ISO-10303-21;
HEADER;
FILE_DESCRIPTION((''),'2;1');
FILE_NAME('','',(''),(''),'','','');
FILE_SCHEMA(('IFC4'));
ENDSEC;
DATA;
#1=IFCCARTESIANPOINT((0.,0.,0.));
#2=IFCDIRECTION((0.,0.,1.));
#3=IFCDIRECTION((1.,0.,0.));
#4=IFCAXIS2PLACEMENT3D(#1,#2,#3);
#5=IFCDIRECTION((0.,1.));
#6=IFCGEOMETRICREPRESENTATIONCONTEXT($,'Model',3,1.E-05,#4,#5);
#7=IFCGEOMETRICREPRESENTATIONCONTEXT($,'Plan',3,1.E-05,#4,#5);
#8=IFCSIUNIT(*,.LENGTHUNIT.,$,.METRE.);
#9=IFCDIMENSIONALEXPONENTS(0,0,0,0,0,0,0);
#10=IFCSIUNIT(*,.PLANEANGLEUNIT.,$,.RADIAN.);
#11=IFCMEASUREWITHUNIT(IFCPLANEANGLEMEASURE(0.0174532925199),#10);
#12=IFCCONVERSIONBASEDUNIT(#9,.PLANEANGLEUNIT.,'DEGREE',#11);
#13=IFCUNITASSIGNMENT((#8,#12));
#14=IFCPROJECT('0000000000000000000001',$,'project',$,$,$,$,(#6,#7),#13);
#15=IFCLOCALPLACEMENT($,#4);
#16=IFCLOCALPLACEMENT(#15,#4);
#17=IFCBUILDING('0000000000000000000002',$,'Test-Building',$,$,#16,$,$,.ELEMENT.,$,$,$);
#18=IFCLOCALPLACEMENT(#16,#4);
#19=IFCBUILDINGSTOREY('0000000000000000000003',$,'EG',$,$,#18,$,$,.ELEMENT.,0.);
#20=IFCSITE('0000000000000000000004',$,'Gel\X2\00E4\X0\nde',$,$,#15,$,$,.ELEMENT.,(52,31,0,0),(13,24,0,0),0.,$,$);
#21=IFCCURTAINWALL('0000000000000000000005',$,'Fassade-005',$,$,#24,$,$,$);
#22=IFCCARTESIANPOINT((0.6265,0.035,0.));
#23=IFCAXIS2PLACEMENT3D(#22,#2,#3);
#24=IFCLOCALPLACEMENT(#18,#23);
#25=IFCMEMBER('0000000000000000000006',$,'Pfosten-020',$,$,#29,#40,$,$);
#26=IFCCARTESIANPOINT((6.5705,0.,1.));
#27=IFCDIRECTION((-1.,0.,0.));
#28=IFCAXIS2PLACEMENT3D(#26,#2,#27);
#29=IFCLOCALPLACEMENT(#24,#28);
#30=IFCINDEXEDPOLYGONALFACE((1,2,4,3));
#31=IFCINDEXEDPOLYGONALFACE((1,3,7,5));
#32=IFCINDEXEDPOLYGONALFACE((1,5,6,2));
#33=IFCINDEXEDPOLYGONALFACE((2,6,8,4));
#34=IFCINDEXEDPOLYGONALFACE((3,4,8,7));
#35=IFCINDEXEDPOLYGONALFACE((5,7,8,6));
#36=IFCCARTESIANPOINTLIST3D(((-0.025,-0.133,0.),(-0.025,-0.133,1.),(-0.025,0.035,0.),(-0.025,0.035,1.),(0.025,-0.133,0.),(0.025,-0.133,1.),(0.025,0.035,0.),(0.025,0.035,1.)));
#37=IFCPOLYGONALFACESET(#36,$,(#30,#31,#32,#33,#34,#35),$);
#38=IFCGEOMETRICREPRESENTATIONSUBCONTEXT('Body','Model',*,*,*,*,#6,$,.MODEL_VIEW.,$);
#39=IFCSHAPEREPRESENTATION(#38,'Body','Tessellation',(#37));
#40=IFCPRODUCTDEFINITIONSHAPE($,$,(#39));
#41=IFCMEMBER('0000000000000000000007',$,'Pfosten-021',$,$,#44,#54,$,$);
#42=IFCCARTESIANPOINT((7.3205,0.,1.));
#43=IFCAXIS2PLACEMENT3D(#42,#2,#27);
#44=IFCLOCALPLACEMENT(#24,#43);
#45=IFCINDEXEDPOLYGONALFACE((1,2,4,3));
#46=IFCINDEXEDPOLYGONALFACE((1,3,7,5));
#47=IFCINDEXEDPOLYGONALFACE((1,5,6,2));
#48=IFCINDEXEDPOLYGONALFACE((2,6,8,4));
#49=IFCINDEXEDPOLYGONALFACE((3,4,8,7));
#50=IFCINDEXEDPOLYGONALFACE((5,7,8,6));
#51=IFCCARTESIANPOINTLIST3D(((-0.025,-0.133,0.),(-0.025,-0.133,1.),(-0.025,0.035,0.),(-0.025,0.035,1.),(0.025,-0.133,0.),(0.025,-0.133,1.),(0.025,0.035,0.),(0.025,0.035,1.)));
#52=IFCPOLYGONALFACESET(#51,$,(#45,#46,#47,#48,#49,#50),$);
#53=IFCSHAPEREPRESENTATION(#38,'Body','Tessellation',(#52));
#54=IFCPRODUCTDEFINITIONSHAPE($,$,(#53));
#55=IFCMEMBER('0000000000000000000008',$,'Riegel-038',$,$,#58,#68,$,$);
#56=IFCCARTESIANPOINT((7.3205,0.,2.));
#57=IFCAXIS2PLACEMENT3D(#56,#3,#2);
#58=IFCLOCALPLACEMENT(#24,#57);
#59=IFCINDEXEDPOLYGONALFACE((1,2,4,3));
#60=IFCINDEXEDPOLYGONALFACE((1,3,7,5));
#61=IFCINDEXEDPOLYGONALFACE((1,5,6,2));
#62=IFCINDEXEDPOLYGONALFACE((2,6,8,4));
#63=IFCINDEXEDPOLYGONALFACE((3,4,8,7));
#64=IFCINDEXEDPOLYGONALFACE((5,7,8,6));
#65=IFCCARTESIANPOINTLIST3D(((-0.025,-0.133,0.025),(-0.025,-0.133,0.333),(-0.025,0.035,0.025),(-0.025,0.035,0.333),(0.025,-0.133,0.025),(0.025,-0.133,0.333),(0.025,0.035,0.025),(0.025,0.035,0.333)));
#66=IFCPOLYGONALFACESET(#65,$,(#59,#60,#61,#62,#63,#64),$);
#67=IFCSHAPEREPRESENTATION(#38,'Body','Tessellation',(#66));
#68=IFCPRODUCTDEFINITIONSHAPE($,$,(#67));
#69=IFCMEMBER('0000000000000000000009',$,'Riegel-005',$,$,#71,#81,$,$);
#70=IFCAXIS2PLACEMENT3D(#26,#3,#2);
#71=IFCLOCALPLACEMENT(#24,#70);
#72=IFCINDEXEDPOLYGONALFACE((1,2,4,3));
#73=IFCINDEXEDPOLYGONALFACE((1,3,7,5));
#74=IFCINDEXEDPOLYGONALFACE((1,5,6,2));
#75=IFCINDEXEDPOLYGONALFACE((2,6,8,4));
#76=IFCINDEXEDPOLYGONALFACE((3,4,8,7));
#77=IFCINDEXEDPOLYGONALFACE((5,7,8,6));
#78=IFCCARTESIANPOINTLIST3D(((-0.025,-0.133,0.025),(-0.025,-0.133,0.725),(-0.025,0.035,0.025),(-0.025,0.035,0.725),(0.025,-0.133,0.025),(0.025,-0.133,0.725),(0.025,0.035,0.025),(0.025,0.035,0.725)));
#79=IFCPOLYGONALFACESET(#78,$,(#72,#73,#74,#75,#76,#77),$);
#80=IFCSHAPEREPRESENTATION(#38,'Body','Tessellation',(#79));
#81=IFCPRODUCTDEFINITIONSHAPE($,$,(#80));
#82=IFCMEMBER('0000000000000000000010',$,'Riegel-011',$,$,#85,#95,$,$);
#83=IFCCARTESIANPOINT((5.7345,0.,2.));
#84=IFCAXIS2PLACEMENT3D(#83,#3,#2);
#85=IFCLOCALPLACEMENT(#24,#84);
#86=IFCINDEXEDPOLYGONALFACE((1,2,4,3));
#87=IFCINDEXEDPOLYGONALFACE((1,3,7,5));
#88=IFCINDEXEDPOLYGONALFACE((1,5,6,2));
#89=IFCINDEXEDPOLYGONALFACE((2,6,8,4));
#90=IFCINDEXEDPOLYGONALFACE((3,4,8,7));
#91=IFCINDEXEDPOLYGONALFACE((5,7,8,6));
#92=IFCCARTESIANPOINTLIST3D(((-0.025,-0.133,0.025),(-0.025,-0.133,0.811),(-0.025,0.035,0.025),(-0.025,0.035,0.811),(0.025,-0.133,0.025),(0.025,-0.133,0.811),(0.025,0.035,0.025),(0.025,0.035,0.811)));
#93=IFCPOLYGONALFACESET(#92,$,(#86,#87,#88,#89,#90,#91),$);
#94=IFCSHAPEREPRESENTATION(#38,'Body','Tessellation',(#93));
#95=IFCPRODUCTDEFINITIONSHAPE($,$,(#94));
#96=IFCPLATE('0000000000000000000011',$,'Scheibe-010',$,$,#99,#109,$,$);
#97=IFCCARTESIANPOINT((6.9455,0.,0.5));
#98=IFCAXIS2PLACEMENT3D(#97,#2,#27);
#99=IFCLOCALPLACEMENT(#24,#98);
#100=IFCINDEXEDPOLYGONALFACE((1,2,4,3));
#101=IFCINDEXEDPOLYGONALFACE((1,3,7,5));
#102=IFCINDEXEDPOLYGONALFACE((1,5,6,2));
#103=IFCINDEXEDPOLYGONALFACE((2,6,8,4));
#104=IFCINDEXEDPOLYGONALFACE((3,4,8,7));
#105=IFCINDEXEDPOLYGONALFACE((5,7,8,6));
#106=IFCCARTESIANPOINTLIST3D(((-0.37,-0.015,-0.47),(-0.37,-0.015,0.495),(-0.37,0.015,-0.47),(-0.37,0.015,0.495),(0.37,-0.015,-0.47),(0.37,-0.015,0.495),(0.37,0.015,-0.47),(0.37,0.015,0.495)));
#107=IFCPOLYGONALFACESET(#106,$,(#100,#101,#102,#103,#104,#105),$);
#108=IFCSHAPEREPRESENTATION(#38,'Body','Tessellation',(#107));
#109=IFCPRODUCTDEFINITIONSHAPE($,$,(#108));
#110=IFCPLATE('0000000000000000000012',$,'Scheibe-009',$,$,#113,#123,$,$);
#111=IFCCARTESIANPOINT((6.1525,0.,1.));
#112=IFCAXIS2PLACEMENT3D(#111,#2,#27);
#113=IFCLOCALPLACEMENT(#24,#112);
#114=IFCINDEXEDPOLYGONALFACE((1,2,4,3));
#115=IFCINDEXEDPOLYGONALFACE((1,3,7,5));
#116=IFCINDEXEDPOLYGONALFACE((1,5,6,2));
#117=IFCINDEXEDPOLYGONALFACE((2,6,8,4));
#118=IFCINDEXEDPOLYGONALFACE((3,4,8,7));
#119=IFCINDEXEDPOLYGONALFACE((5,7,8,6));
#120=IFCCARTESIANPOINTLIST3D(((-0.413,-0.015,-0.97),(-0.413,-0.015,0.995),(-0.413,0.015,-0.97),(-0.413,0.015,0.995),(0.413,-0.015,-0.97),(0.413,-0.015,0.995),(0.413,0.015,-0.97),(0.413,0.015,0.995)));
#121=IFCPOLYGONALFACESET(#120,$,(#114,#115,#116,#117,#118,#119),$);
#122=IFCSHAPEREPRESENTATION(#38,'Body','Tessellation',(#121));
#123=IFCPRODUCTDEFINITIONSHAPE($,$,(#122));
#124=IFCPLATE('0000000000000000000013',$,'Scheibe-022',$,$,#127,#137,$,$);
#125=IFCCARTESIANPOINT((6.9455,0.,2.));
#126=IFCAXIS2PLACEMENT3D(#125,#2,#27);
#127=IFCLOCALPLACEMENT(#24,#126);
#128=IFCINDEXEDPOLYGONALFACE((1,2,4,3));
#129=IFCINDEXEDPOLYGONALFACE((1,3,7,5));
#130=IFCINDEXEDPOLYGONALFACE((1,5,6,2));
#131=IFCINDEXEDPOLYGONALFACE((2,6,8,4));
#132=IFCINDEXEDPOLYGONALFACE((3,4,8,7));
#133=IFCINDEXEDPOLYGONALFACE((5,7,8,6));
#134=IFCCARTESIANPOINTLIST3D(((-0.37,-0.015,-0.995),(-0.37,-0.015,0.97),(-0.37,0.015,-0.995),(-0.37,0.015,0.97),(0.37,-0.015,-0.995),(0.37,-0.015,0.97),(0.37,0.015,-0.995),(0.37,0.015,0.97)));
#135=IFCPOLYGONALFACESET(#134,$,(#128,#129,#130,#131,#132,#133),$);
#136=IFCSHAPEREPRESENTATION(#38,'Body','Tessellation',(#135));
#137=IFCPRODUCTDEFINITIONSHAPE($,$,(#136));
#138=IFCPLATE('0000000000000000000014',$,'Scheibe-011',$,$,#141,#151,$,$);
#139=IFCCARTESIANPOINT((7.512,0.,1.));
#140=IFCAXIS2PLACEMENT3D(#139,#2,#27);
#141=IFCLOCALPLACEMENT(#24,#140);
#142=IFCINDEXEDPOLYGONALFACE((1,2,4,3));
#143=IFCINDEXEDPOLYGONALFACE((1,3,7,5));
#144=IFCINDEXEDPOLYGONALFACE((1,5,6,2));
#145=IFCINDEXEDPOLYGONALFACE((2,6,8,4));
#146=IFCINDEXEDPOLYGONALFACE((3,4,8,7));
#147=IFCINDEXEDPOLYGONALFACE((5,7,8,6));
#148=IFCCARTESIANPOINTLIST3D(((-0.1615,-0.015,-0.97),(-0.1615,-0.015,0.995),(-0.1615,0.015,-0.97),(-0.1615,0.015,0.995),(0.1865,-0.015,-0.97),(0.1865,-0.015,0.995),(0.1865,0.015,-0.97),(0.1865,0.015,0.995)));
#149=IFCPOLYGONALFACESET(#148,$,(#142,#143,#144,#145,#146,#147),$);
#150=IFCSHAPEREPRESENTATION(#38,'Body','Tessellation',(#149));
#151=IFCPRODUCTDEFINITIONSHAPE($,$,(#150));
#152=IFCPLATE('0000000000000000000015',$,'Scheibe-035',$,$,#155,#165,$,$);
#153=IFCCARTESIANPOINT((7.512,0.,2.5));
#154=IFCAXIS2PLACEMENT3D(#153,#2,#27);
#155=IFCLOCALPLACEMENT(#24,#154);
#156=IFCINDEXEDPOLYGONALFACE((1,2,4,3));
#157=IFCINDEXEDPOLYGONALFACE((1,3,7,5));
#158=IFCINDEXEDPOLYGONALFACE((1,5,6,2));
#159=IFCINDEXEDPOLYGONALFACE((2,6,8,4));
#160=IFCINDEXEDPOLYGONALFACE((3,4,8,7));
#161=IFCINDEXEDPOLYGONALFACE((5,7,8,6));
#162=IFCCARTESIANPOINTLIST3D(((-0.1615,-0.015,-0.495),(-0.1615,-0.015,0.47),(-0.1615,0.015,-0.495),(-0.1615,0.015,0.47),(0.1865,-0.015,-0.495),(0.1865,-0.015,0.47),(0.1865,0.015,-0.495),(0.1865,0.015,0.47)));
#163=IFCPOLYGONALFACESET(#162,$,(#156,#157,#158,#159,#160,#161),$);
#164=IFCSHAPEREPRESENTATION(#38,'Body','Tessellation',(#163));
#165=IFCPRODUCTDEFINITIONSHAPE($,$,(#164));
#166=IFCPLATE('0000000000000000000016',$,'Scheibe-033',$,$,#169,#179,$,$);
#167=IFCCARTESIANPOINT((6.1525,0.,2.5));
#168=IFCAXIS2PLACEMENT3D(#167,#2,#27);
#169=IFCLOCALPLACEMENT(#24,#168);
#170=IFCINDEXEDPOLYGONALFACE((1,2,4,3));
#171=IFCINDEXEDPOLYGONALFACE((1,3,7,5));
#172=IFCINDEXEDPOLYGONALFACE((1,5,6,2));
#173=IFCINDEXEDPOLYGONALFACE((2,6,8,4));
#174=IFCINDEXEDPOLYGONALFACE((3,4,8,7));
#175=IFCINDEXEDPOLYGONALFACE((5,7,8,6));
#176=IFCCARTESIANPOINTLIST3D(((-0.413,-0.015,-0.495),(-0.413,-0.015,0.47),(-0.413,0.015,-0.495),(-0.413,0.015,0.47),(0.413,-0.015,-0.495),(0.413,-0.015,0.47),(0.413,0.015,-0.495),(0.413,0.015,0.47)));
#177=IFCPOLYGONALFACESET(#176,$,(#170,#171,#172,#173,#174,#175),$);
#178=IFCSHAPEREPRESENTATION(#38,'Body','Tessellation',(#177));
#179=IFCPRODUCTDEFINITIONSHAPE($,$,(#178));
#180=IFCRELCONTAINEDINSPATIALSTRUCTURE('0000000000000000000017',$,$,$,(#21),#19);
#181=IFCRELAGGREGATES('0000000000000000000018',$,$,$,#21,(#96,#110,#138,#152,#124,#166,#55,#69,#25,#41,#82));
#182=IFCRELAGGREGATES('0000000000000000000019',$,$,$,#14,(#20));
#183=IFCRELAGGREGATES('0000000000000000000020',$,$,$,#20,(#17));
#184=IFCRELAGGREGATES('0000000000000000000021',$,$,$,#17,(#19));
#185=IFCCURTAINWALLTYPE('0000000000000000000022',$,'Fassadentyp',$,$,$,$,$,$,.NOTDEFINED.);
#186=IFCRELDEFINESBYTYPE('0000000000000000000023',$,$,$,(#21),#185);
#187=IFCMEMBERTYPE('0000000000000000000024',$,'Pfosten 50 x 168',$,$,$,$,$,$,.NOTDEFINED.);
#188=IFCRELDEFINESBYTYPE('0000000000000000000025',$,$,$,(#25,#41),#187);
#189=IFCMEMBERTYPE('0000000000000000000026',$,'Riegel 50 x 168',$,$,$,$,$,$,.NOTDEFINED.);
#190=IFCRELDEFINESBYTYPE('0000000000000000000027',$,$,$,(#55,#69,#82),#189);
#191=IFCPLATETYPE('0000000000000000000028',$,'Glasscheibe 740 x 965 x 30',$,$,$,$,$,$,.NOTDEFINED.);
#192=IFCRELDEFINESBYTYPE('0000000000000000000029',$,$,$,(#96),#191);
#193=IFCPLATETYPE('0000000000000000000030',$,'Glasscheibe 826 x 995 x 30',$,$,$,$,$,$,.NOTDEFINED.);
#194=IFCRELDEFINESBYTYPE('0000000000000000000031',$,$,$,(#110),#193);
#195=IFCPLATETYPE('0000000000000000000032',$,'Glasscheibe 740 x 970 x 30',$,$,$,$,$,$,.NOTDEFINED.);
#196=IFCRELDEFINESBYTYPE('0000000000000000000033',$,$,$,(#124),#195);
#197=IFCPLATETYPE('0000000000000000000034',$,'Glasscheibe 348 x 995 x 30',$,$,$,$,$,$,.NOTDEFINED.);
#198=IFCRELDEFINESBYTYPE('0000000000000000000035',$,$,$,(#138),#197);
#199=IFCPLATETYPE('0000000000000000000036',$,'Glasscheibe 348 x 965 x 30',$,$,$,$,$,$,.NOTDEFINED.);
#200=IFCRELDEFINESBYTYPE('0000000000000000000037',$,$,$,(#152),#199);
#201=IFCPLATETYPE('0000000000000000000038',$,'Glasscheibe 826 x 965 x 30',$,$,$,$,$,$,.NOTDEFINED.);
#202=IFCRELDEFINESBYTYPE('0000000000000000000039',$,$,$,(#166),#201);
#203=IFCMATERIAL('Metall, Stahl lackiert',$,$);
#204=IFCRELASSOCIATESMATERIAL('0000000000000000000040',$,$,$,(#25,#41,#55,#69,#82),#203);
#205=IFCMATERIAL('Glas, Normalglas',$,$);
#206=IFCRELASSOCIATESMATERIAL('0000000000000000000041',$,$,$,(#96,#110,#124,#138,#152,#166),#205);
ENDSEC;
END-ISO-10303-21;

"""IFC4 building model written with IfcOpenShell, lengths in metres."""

from ifc_helpers import new_model, entity, si_unit, converted_unit, direction, frame, origin_with_axes, place, context, subcontext, project, spatial, polyline, outline, extrude, material, type_object, element, aggregate, save


model = new_model("IFC4")

# Units and contexts
model_context = context("Model", 3, precision=1e-05, world=origin_with_axes(), true_north=direction((0.0, 1.0)))
plan_context = context("Plan", 3, precision=1e-05, world=origin_with_axes(), true_north=direction((0.0, 1.0)))
body_context = subcontext(model_context, "Body", "Model", "MODEL_VIEW")
ifc_project = project(units=[si_unit("LENGTHUNIT", "METRE"), converted_unit("PLANEANGLEUNIT", "DEGREE", entity("IfcPlaneAngleMeasure", 0.0174532925199), si_unit("PLANEANGLEUNIT", "RADIAN"), dimensions=[0, 0, 0, 0, 0, 0, 0])], contexts=[model_context, plan_context])

# Site, building, storey
site_placement = place(None, origin_with_axes())
site = spatial("IfcSite", under=ifc_project, at=site_placement, Name="Gelände", CompositionType="ELEMENT", RefLatitude=(52, 31, 0, 0), RefLongitude=(13, 24, 0, 0), RefElevation=0.0)
building_placement = place(site_placement, origin_with_axes())
building = spatial("IfcBuilding", under=site, at=building_placement, Name="Test-Building", CompositionType="ELEMENT")
storey_placement = place(building_placement, origin_with_axes())
storey = spatial("IfcBuildingStorey", under=building, at=storey_placement, Name="EG", CompositionType="ELEMENT", Elevation=0.0)

# Curtain wall, members, plates
curtain_wall_type = type_object("IfcCurtainWallType", Name="Fassadentyp", PredefinedType="NOTDEFINED")
curtain_wall_placement = place(storey_placement, frame((0.6265, 0.035, 0.0), z_axis=(0.0, 0.0, 1.0), x_axis=(1.0, 0.0, 0.0)))
curtain_wall = element("IfcCurtainWall", 1, at=curtain_wall_placement, inside=storey, type_object=curtain_wall_type, Name="Fassade-005")
ifc_material_1 = material(Name="Metall, Stahl lackiert")
member_type_1 = type_object("IfcMemberType", Name="Pfosten 50 x 168", PredefinedType="NOTDEFINED")
member_1_placement = place(curtain_wall_placement, frame((6.5705, 0.0, 1.0), z_axis=(0.0, 0.0, 1.0), x_axis=(-1.0, 0.0, 0.0)))
member_1 = element("IfcMember", 2, at=member_1_placement, type_object=member_type_1, material=ifc_material_1, Name="Pfosten-020", context=body_context, shape_type="SweptSolid", body=[
    extrude(outline(polyline([(-0.025, 0.133), (-0.025, -0.035), (0.025, -0.035), (0.025, 0.133), (-0.025, 0.133)])), frame((0.0, 0.0, 0.0), z_axis=(0.0, 0.0, 1.0), x_axis=(-1.0, 0.0, 0.0)), (0.0, 0.0, 1.0), 1.0),
])
member_2_placement = place(curtain_wall_placement, frame((7.3205, 0.0, 1.0), z_axis=(0.0, 0.0, 1.0), x_axis=(-1.0, 0.0, 0.0)))
member_2 = element("IfcMember", 3, at=member_2_placement, type_object=member_type_1, material=ifc_material_1, Name="Pfosten-021", context=body_context, shape_type="SweptSolid", body=[
    extrude(outline(polyline([(-0.025, 0.133), (-0.025, -0.035), (0.025, -0.035), (0.025, 0.133), (-0.025, 0.133)])), frame((0.0, 0.0, 0.0), z_axis=(0.0, 0.0, 1.0), x_axis=(-1.0, 0.0, 0.0)), (0.0, 0.0, 1.0), 1.0),
])
member_type_2 = type_object("IfcMemberType", Name="Riegel 50 x 168", PredefinedType="NOTDEFINED")
member_3_placement = place(curtain_wall_placement, frame((7.3205, 0.0, 2.0), z_axis=(1.0, 0.0, 0.0), x_axis=(0.0, 0.0, 1.0)))
member_3 = element("IfcMember", 4, at=member_3_placement, type_object=member_type_2, material=ifc_material_1, Name="Riegel-038", context=body_context, shape_type="SweptSolid", body=[
    extrude(outline(polyline([(-0.133, -0.025), (0.035, -0.025), (0.035, 0.025), (-0.133, 0.025), (-0.133, -0.025)])), frame((0.0, 0.0, 0.025), z_axis=(0.0, 0.0, 1.0), x_axis=(0.0, 1.0, 0.0)), (0.0, 0.0, 1.0), 0.308),
])
member_4_placement = place(curtain_wall_placement, frame((6.5705, 0.0, 1.0), z_axis=(1.0, 0.0, 0.0), x_axis=(0.0, 0.0, 1.0)))
member_4 = element("IfcMember", 5, at=member_4_placement, type_object=member_type_2, material=ifc_material_1, Name="Riegel-005", context=body_context, shape_type="SweptSolid", body=[
    extrude(outline(polyline([(-0.133, -0.025), (0.035, -0.025), (0.035, 0.025), (-0.133, 0.025), (-0.133, -0.025)])), frame((0.0, 0.0, 0.025), z_axis=(0.0, 0.0, 1.0), x_axis=(0.0, 1.0, 0.0)), (0.0, 0.0, 1.0), 0.7),
])
member_5_placement = place(curtain_wall_placement, frame((5.7345, 0.0, 2.0), z_axis=(1.0, 0.0, 0.0), x_axis=(0.0, 0.0, 1.0)))
member_5 = element("IfcMember", 6, at=member_5_placement, type_object=member_type_2, material=ifc_material_1, Name="Riegel-011", context=body_context, shape_type="SweptSolid", body=[
    extrude(outline(polyline([(-0.133, -0.025), (0.035, -0.025), (0.035, 0.025), (-0.133, 0.025), (-0.133, -0.025)])), frame((0.0, 0.0, 0.025), z_axis=(0.0, 0.0, 1.0), x_axis=(0.0, 1.0, 0.0)), (0.0, 0.0, 1.0), 0.786),
])
ifc_material_2 = material(Name="Glas, Normalglas")
plate_type_1 = type_object("IfcPlateType", Name="Glasscheibe 740 x 965 x 30", PredefinedType="NOTDEFINED")
plate_1_placement = place(curtain_wall_placement, frame((6.9455, 0.0, 0.5), z_axis=(0.0, 0.0, 1.0), x_axis=(-1.0, 0.0, 0.0)))
plate_1 = element("IfcPlate", 7, at=plate_1_placement, type_object=plate_type_1, material=ifc_material_2, Name="Scheibe-010", context=body_context, shape_type="SweptSolid", body=[
    extrude(outline(polyline([(-0.37, -0.495), (0.37, -0.495), (0.37, 0.47), (-0.37, 0.47), (-0.37, -0.495)])), frame((0.0, -0.015, 0.0), z_axis=(0.0, 1.0, 0.0), x_axis=(1.0, 0.0, 0.0)), (0.0, 0.0, 1.0), 0.03),
])
plate_type_2 = type_object("IfcPlateType", Name="Glasscheibe 826 x 995 x 30", PredefinedType="NOTDEFINED")
plate_2_placement = place(curtain_wall_placement, frame((6.1525, 0.0, 1.0), z_axis=(0.0, 0.0, 1.0), x_axis=(-1.0, 0.0, 0.0)))
plate_2 = element("IfcPlate", 8, at=plate_2_placement, type_object=plate_type_2, material=ifc_material_2, Name="Scheibe-009", context=body_context, shape_type="SweptSolid", body=[
    extrude(outline(polyline([(-0.413, -0.995), (0.413, -0.995), (0.413, 0.97), (-0.413, 0.97), (-0.413, -0.995)])), frame((0.0, -0.015, 0.0), z_axis=(0.0, 1.0, 0.0), x_axis=(1.0, 0.0, 0.0)), (0.0, 0.0, 1.0), 0.03),
])
plate_type_3 = type_object("IfcPlateType", Name="Glasscheibe 740 x 970 x 30", PredefinedType="NOTDEFINED")
plate_3_placement = place(curtain_wall_placement, frame((6.9455, 0.0, 2.0), z_axis=(0.0, 0.0, 1.0), x_axis=(-1.0, 0.0, 0.0)))
plate_3 = element("IfcPlate", 9, at=plate_3_placement, type_object=plate_type_3, material=ifc_material_2, Name="Scheibe-022", context=body_context, shape_type="SweptSolid", body=[
    extrude(outline(polyline([(-0.37, -0.97), (0.37, -0.97), (0.37, 0.995), (-0.37, 0.995), (-0.37, -0.97)])), frame((0.0, -0.015, 0.0), z_axis=(0.0, 1.0, 0.0), x_axis=(1.0, 0.0, 0.0)), (0.0, 0.0, 1.0), 0.03),
])
plate_type_4 = type_object("IfcPlateType", Name="Glasscheibe 348 x 995 x 30", PredefinedType="NOTDEFINED")
plate_4_placement = place(curtain_wall_placement, frame((7.512, 0.0, 1.0), z_axis=(0.0, 0.0, 1.0), x_axis=(-1.0, 0.0, 0.0)))
plate_4 = element("IfcPlate", 10, at=plate_4_placement, type_object=plate_type_4, material=ifc_material_2, Name="Scheibe-011", context=body_context, shape_type="SweptSolid", body=[
    extrude(outline(polyline([(-0.1615, -0.995), (0.1865, -0.995), (0.1865, 0.97), (-0.1615, 0.97), (-0.1615, -0.995)])), frame((0.0, -0.015, 0.0), z_axis=(0.0, 1.0, 0.0), x_axis=(1.0, 0.0, 0.0)), (0.0, 0.0, 1.0), 0.03),
])
plate_type_5 = type_object("IfcPlateType", Name="Glasscheibe 348 x 965 x 30", PredefinedType="NOTDEFINED")
plate_5_placement = place(curtain_wall_placement, frame((7.512, 0.0, 2.5), z_axis=(0.0, 0.0, 1.0), x_axis=(-1.0, 0.0, 0.0)))
plate_5 = element("IfcPlate", 11, at=plate_5_placement, type_object=plate_type_5, material=ifc_material_2, Name="Scheibe-035", context=body_context, shape_type="SweptSolid", body=[
    extrude(outline(polyline([(-0.1615, -0.47), (0.1865, -0.47), (0.1865, 0.495), (-0.1615, 0.495), (-0.1615, -0.47)])), frame((0.0, -0.015, 0.0), z_axis=(0.0, 1.0, 0.0), x_axis=(1.0, 0.0, 0.0)), (0.0, 0.0, 1.0), 0.03),
])
plate_type_6 = type_object("IfcPlateType", Name="Glasscheibe 826 x 965 x 30", PredefinedType="NOTDEFINED")
plate_6_placement = place(curtain_wall_placement, frame((6.1525, 0.0, 2.5), z_axis=(0.0, 0.0, 1.0), x_axis=(-1.0, 0.0, 0.0)))
plate_6 = element("IfcPlate", 12, at=plate_6_placement, type_object=plate_type_6, material=ifc_material_2, Name="Scheibe-033", context=body_context, shape_type="SweptSolid", body=[
    extrude(outline(polyline([(-0.413, -0.47), (0.413, -0.47), (0.413, 0.495), (-0.413, 0.495), (-0.413, -0.47)])), frame((0.0, -0.015, 0.0), z_axis=(0.0, 1.0, 0.0), x_axis=(1.0, 0.0, 0.0)), (0.0, 0.0, 1.0), 0.03),
])
aggregate(curtain_wall, [plate_1, plate_2, plate_4, plate_5, plate_3, plate_6, member_3, member_4, member_1, member_2, member_5])

save(model, "model.ifc")
